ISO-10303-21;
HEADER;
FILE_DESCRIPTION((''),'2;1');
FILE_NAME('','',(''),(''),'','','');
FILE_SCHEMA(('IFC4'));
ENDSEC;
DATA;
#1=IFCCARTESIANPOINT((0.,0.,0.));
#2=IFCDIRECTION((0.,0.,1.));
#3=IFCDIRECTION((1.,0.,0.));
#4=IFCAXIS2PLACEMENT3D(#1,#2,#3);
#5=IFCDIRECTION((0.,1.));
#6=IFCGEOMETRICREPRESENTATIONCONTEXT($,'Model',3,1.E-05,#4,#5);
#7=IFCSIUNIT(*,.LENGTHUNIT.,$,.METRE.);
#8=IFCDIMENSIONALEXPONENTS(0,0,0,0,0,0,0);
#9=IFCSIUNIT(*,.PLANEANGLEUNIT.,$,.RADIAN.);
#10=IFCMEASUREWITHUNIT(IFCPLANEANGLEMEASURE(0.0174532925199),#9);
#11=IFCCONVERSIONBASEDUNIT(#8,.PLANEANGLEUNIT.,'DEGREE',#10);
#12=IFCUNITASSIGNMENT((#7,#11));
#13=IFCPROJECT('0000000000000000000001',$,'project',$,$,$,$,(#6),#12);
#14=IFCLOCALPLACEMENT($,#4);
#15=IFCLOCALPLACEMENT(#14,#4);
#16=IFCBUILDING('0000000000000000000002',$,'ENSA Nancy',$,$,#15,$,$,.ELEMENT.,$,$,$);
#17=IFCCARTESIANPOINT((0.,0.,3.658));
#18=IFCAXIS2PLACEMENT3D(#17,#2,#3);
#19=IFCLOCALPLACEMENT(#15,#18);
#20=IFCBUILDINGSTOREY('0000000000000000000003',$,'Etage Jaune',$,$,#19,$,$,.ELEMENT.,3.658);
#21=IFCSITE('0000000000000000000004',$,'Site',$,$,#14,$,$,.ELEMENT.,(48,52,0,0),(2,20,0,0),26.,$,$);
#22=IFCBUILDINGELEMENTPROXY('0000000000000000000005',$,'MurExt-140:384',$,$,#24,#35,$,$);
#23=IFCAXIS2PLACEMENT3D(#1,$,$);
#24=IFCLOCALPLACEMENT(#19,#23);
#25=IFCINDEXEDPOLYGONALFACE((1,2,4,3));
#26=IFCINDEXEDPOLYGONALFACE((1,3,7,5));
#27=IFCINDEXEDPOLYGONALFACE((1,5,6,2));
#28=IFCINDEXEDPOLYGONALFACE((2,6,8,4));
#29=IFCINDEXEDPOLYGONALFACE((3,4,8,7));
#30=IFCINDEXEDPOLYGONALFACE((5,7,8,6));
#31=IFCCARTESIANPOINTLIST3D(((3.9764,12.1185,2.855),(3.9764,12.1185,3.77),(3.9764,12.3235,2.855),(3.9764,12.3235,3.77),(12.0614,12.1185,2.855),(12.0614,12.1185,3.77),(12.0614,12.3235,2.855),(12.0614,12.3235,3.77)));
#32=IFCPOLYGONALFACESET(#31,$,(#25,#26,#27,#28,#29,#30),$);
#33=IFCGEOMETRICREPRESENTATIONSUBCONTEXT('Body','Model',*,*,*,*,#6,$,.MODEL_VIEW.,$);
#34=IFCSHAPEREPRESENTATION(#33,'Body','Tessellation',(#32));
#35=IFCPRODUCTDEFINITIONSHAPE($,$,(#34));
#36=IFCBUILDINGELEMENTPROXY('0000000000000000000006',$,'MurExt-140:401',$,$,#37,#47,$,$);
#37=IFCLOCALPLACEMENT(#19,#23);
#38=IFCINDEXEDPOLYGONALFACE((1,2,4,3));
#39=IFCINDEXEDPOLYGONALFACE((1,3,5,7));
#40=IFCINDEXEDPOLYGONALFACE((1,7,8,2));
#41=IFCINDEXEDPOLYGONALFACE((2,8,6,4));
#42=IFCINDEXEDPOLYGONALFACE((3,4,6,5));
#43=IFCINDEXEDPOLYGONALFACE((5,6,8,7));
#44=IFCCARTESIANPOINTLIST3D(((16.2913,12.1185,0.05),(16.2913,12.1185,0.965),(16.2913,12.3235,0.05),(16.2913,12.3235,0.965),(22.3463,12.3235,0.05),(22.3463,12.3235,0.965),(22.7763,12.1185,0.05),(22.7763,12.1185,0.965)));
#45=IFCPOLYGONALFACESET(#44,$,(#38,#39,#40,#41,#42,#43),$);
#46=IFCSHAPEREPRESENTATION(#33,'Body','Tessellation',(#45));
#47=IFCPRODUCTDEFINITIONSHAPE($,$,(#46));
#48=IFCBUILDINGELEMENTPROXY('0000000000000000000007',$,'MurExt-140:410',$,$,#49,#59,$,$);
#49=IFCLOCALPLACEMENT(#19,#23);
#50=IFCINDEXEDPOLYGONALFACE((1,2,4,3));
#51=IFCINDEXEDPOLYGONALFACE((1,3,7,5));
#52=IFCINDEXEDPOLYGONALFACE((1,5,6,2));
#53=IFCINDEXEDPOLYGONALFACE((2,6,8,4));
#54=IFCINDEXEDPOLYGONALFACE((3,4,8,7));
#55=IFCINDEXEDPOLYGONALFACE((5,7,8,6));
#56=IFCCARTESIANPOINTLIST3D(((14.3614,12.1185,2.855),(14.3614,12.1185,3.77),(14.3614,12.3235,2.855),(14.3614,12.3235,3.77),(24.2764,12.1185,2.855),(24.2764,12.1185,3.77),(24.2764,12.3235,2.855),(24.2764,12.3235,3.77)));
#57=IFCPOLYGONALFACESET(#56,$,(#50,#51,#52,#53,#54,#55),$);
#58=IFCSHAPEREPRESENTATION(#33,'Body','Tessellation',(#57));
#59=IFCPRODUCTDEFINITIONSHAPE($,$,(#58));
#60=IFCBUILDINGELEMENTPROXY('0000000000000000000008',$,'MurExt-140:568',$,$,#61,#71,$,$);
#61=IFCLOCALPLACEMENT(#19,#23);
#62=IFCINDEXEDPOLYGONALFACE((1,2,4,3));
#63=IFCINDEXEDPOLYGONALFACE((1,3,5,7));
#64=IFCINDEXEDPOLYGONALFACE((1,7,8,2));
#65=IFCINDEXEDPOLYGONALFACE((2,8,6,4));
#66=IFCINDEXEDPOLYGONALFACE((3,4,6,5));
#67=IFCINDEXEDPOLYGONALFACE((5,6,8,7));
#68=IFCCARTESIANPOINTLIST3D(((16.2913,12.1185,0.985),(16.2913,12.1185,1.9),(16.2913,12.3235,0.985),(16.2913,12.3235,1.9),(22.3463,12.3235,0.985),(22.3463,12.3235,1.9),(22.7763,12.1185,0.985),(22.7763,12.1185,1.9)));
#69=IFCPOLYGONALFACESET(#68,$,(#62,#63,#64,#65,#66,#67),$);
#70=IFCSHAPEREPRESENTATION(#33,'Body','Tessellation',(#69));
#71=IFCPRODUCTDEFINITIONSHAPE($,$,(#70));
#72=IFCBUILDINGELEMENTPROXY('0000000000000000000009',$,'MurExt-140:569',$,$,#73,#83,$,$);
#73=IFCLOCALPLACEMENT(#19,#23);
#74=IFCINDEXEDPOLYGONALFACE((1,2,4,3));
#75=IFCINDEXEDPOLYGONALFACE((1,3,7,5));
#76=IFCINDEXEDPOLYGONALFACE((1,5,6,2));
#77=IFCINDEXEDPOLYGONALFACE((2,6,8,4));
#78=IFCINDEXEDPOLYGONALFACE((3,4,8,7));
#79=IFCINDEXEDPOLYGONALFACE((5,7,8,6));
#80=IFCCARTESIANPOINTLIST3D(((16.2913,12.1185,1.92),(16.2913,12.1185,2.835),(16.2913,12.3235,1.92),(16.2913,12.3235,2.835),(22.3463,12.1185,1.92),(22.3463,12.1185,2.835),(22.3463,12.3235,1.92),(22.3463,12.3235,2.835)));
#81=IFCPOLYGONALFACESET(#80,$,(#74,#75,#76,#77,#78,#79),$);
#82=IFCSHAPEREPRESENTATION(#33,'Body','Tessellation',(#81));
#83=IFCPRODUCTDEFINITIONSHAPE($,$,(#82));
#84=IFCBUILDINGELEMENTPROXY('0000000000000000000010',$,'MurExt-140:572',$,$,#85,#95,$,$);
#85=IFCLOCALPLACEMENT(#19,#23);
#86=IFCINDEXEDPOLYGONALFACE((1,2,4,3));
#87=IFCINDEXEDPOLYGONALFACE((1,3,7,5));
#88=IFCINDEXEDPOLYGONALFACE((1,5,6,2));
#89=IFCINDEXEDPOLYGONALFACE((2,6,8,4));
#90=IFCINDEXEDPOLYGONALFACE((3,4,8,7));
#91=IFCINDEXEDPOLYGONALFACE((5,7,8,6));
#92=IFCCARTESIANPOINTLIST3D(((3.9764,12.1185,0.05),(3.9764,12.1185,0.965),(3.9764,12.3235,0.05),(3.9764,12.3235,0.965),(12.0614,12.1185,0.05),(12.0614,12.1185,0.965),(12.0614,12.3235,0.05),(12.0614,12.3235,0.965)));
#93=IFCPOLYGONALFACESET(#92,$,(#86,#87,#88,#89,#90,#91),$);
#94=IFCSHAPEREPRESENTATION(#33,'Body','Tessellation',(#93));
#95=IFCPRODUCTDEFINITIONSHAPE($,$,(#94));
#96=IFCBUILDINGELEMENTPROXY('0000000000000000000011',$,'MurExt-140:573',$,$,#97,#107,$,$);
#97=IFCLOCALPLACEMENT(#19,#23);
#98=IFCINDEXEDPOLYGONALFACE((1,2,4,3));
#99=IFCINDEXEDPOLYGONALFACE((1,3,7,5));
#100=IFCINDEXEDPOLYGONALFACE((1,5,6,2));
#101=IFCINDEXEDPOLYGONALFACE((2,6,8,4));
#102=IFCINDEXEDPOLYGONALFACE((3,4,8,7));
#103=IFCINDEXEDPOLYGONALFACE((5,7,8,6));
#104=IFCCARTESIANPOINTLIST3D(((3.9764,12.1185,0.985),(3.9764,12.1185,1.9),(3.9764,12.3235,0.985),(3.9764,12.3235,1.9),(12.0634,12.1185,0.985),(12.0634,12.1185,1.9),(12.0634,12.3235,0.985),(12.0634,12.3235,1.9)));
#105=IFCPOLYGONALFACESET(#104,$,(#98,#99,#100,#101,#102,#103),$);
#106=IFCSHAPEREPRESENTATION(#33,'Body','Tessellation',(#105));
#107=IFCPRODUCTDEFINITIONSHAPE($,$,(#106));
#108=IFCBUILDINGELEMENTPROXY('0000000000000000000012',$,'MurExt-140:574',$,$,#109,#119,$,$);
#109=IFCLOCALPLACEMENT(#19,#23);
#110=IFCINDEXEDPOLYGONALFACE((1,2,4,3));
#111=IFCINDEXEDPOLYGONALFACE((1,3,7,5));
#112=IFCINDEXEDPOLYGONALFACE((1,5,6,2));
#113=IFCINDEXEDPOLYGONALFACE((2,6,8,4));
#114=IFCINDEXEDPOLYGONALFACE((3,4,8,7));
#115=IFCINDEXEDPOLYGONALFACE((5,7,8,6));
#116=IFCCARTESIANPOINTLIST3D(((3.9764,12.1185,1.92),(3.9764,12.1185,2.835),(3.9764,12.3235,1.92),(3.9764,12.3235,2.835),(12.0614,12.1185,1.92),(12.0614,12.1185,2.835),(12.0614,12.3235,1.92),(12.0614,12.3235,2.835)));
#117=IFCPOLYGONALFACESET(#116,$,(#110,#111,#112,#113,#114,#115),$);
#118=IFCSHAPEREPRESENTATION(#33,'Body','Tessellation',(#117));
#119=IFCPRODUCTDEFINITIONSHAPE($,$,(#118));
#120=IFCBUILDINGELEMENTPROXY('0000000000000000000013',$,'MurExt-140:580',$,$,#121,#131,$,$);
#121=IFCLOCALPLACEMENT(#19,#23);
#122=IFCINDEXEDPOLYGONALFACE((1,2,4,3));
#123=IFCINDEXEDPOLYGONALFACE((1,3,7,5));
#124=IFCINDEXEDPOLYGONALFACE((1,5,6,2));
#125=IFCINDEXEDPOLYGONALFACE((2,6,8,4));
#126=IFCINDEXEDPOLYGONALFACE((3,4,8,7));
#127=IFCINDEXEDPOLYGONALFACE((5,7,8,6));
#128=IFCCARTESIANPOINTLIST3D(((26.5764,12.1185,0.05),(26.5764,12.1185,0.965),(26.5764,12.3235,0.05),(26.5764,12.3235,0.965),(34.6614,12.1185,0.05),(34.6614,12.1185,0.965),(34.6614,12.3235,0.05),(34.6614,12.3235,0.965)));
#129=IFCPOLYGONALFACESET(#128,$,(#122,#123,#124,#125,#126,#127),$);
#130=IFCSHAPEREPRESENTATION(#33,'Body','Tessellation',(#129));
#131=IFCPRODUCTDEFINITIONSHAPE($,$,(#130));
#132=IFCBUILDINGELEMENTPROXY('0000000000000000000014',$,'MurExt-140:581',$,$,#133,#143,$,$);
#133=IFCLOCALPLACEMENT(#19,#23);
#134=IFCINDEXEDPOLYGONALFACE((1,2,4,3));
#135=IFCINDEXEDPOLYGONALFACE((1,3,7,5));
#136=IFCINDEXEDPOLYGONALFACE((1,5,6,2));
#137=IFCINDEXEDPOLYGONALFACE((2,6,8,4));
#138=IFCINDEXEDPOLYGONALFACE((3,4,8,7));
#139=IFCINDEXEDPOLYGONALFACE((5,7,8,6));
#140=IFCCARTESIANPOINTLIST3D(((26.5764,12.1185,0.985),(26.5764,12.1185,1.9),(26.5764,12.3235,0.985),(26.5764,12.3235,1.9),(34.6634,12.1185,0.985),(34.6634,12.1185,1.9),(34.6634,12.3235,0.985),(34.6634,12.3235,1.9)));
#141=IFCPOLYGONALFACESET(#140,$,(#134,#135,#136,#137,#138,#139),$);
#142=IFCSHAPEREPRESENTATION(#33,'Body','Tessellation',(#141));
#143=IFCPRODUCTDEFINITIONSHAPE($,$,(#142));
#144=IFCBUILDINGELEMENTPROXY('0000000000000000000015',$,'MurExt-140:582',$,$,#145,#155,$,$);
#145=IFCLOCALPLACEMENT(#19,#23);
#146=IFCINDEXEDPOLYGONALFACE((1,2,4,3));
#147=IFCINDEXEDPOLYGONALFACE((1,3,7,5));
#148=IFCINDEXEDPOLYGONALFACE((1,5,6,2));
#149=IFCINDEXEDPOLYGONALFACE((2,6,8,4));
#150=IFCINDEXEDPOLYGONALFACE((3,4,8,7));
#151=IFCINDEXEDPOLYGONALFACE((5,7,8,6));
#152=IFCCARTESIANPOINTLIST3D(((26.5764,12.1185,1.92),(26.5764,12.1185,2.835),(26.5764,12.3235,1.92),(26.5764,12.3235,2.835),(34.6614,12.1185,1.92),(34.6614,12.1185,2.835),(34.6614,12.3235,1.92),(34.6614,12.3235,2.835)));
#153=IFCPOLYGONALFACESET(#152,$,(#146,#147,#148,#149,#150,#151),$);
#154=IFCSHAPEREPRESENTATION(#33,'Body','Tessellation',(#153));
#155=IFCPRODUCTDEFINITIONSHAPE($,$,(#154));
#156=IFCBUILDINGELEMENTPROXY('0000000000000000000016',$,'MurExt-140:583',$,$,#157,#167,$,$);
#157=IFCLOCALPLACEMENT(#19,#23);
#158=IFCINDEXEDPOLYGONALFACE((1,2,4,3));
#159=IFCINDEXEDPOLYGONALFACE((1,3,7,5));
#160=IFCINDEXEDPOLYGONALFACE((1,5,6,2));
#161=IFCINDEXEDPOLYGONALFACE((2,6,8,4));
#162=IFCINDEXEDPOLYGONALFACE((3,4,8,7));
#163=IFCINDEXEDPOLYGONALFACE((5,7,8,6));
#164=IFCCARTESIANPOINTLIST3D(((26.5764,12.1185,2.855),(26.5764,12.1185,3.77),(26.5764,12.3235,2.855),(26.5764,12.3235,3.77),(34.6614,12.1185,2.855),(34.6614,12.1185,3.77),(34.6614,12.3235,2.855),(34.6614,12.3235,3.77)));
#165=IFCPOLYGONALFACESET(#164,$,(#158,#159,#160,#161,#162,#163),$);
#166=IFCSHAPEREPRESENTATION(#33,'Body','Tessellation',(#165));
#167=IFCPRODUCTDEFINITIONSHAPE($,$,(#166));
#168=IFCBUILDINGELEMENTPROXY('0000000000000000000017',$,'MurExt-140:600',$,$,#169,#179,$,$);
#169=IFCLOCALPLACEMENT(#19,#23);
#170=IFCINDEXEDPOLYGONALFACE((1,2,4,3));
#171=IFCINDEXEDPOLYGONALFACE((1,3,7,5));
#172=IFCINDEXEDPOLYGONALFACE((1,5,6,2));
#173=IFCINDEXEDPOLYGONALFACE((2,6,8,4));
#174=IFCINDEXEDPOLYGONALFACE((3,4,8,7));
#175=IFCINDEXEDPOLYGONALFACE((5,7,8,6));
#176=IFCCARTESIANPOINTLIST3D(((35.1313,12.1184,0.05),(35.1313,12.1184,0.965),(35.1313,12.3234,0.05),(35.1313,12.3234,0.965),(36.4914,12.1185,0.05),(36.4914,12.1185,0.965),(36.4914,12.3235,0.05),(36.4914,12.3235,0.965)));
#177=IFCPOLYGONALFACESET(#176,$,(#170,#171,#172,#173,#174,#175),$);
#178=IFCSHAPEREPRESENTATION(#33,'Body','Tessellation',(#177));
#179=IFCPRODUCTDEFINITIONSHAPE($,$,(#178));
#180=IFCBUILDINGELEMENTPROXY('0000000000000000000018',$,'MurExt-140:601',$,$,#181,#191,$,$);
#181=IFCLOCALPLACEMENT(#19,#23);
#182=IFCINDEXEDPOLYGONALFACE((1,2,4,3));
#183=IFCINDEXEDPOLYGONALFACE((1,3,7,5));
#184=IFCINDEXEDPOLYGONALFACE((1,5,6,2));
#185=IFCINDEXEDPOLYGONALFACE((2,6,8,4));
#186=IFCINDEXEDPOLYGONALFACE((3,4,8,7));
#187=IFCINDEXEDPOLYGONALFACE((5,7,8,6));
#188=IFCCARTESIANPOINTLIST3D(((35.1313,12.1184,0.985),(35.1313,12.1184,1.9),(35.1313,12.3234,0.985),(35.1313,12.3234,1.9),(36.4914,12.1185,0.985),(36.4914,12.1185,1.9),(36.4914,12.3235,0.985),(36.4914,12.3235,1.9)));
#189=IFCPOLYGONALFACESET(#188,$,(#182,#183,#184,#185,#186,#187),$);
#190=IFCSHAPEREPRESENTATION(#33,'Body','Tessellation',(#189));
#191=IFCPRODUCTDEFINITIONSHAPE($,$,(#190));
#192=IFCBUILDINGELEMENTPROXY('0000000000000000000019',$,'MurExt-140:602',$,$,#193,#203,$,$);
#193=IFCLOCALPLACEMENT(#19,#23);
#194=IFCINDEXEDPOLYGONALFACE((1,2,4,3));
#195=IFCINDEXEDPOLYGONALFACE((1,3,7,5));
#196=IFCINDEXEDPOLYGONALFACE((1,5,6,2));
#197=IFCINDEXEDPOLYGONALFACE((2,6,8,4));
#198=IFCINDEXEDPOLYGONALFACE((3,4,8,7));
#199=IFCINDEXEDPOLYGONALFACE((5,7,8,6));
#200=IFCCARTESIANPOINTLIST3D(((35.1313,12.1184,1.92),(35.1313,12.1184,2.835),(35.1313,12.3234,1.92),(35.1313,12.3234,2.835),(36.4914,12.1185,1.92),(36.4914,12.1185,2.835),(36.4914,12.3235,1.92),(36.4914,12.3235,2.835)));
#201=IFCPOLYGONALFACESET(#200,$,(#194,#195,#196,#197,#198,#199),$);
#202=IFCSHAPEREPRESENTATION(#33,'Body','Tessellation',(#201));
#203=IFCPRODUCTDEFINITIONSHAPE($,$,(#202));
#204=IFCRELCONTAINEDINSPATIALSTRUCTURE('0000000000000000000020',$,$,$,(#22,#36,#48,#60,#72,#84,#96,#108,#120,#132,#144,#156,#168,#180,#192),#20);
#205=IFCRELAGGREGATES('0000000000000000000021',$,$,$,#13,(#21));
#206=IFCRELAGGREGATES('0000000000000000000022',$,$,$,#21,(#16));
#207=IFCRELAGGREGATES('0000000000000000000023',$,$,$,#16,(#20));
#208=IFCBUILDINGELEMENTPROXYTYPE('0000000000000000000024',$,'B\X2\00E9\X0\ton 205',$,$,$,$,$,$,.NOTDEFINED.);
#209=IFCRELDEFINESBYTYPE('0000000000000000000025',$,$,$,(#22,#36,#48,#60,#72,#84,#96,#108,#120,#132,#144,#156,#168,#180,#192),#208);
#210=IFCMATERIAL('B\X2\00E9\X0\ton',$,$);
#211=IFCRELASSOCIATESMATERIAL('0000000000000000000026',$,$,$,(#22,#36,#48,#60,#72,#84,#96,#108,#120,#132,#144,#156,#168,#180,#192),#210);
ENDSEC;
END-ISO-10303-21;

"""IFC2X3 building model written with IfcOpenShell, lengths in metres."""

from ifc_helpers import new_model, entity, si_unit, converted_unit, direction, frame, origin_with_axes, place, context, subcontext, project, spatial, polyline, outline, extrude, material, type_object, element, save


model = new_model("IFC2X3")

# Units and contexts
model_context = context("Model", 3, precision=1e-05, world=origin_with_axes(), true_north=direction((0.0, 1.0)))
body_context = subcontext(model_context, "Body", "Model", "MODEL_VIEW")
ifc_project = project(units=[si_unit("LENGTHUNIT", "METRE"), converted_unit("PLANEANGLEUNIT", "DEGREE", entity("IfcPlaneAngleMeasure", 0.0174532925199), si_unit("PLANEANGLEUNIT", "RADIAN"), dimensions=[0, 0, 0, 0, 0, 0, 0])], contexts=[model_context])

# Site, building, storey
site_placement = place(None, origin_with_axes())
site = spatial("IfcSite", under=ifc_project, at=site_placement, Name="Site", CompositionType="ELEMENT", RefLatitude=(48, 52, 0, 0), RefLongitude=(2, 20, 0, 0), RefElevation=26.0)
building_placement = place(site_placement, origin_with_axes())
building = spatial("IfcBuilding", under=site, at=building_placement, Name="ENSA Nancy", CompositionType="ELEMENT")
storey_placement = place(building_placement, frame((0.0, 0.0, 3.658), z_axis=(0.0, 0.0, 1.0), x_axis=(1.0, 0.0, 0.0)))
storey = spatial("IfcBuildingStorey", under=building, at=storey_placement, Name="Etage Jaune", CompositionType="ELEMENT", Elevation=3.658)

# Building element proxies
ifc_material = material(Name="Béton")
building_element_proxy_type_1 = type_object("IfcBuildingElementProxyType", Name="Béton 205", PredefinedType="NOTDEFINED")
proxy_1_placement = place(storey_placement, frame((3.9764, 12.3235, 2.855), z_axis=(0.0, 0.0, 1.0), x_axis=(1.0, 0.0, 0.0)))
element("IfcBuildingElementProxy", 1, at=proxy_1_placement, inside=storey, type_object=building_element_proxy_type_1, material=ifc_material, Name="MurExt-140:384", context=body_context, shape_type="SweptSolid", body=[
    extrude(outline(polyline([(0.0, -0.205), (8.085, -0.205), (8.085, 0.0), (0.0, 0.0), (0.0, -0.205)])), origin_with_axes(), (0.0, 0.0, 1.0), 0.915),
])
proxy_2_placement = place(storey_placement, frame((16.2913, 12.3235, 0.05), z_axis=(0.0, 0.0, 1.0), x_axis=(1.0, 0.0, 0.0)))
element("IfcBuildingElementProxy", 2, at=proxy_2_placement, inside=storey, type_object=building_element_proxy_type_1, material=ifc_material, Name="MurExt-140:401", context=body_context, shape_type="SweptSolid", body=[
    extrude(outline(polyline([(0.0, -0.205), (6.485, -0.205), (6.055, 0.0), (0.0, 0.0), (0.0, -0.205)])), origin_with_axes(), (0.0, 0.0, 1.0), 0.915),
])
proxy_3_placement = place(storey_placement, frame((14.3614, 12.3235, 2.855), z_axis=(0.0, 0.0, 1.0), x_axis=(1.0, 0.0, 0.0)))
element("IfcBuildingElementProxy", 3, at=proxy_3_placement, inside=storey, type_object=building_element_proxy_type_1, material=ifc_material, Name="MurExt-140:410", context=body_context, shape_type="SweptSolid", body=[
    extrude(outline(polyline([(0.0, -0.205), (9.915, -0.205), (9.915, 0.0), (0.0, 0.0), (0.0, -0.205)])), origin_with_axes(), (0.0, 0.0, 1.0), 0.915),
])
proxy_4_placement = place(storey_placement, frame((16.2913, 12.3235, 0.985), z_axis=(0.0, 0.0, 1.0), x_axis=(1.0, 0.0, 0.0)))
element("IfcBuildingElementProxy", 4, at=proxy_4_placement, inside=storey, type_object=building_element_proxy_type_1, material=ifc_material, Name="MurExt-140:568", context=body_context, shape_type="SweptSolid", body=[
    extrude(outline(polyline([(0.0, -0.205), (6.485, -0.205), (6.055, 0.0), (0.0, 0.0), (0.0, -0.205)])), origin_with_axes(), (0.0, 0.0, 1.0), 0.915),
])
proxy_5_placement = place(storey_placement, frame((16.2913, 12.3235, 1.92), z_axis=(0.0, 0.0, 1.0), x_axis=(1.0, 0.0, 0.0)))
element("IfcBuildingElementProxy", 5, at=proxy_5_placement, inside=storey, type_object=building_element_proxy_type_1, material=ifc_material, Name="MurExt-140:569", context=body_context, shape_type="SweptSolid", body=[
    extrude(outline(polyline([(0.0, -0.205), (6.055, -0.205), (6.055, 0.0), (0.0, 0.0), (0.0, -0.205)])), origin_with_axes(), (0.0, 0.0, 1.0), 0.915),
])
proxy_6_placement = place(storey_placement, frame((3.9764, 12.3235, 0.05), z_axis=(0.0, 0.0, 1.0), x_axis=(1.0, 0.0, 0.0)))
element("IfcBuildingElementProxy", 6, at=proxy_6_placement, inside=storey, type_object=building_element_proxy_type_1, material=ifc_material, Name="MurExt-140:572", context=body_context, shape_type="SweptSolid", body=[
    extrude(outline(polyline([(0.0, -0.205), (8.085, -0.205), (8.085, 0.0), (0.0, 0.0), (0.0, -0.205)])), origin_with_axes(), (0.0, 0.0, 1.0), 0.915),
])
proxy_7_placement = place(storey_placement, frame((3.9764, 12.3235, 0.985), z_axis=(0.0, 0.0, 1.0), x_axis=(1.0, 0.0, 0.0)))
element("IfcBuildingElementProxy", 7, at=proxy_7_placement, inside=storey, type_object=building_element_proxy_type_1, material=ifc_material, Name="MurExt-140:573", context=body_context, shape_type="SweptSolid", body=[
    extrude(outline(polyline([(0.0, -0.205), (8.087, -0.205), (8.087, 0.0), (0.0, 0.0), (0.0, -0.205)])), origin_with_axes(), (0.0, 0.0, 1.0), 0.915),
])
for number, where, z_axis, x_axis, name in (
    (8, (3.9764, 12.3235, 1.92), (0.0, 0.0, 1.0), (1.0, 0.0, 0.0), "MurExt-140:574"),
    (9, (26.5764, 12.3235, 0.05), (0.0, 0.0, 1.0), (1.0, 0.0, 0.0), "MurExt-140:580"),
):
    element("IfcBuildingElementProxy", number, at=place(storey_placement, frame(where, z_axis=z_axis, x_axis=x_axis)), inside=storey, type_object=building_element_proxy_type_1, material=ifc_material, Name=name, context=body_context, shape_type="SweptSolid", body=[
        extrude(outline(polyline([(0.0, -0.205), (8.085, -0.205), (8.085, 0.0), (0.0, 0.0), (0.0, -0.205)])), origin_with_axes(), (0.0, 0.0, 1.0), 0.915),
    ])
proxy_8_placement = place(storey_placement, frame((26.5764, 12.3235, 0.985), z_axis=(0.0, 0.0, 1.0), x_axis=(1.0, 0.0, 0.0)))
element("IfcBuildingElementProxy", 10, at=proxy_8_placement, inside=storey, type_object=building_element_proxy_type_1, material=ifc_material, Name="MurExt-140:581", context=body_context, shape_type="SweptSolid", body=[
    extrude(outline(polyline([(0.0, -0.205), (8.087, -0.205), (8.087, 0.0), (0.0, 0.0), (0.0, -0.205)])), origin_with_axes(), (0.0, 0.0, 1.0), 0.915),
])
for number, where, z_axis, x_axis, name in (
    (11, (26.5764, 12.3235, 1.92), (0.0, 0.0, 1.0), (1.0, 0.0, 0.0), "MurExt-140:582"),
    (12, (26.5764, 12.3235, 2.855), (0.0, 0.0, 1.0), (1.0, 0.0, 0.0), "MurExt-140:583"),
):
    element("IfcBuildingElementProxy", number, at=place(storey_placement, frame(where, z_axis=z_axis, x_axis=x_axis)), inside=storey, type_object=building_element_proxy_type_1, material=ifc_material, Name=name, context=body_context, shape_type="SweptSolid", body=[
        extrude(outline(polyline([(0.0, -0.205), (8.085, -0.205), (8.085, 0.0), (0.0, 0.0), (0.0, -0.205)])), origin_with_axes(), (0.0, 0.0, 1.0), 0.915),
    ])
for number, where, z_axis, x_axis, name in (
    (13, (35.1313, 12.3234, 0.05), (0.0, 0.0, 1.0), (1.0, 0.000034, 0.0), "MurExt-140:600"),
    (14, (35.1313, 12.3234, 0.985), (0.0, 0.0, 1.0), (1.0, 0.000034, 0.0), "MurExt-140:601"),
    (15, (35.1313, 12.3234, 1.92), (0.0, 0.0, 1.0), (1.0, 0.000034, 0.0), "MurExt-140:602"),
):
    element("IfcBuildingElementProxy", number, at=place(storey_placement, frame(where, z_axis=z_axis, x_axis=x_axis)), inside=storey, type_object=building_element_proxy_type_1, material=ifc_material, Name=name, context=body_context, shape_type="SweptSolid", body=[
        extrude(outline(polyline([(0.0, -0.205), (1.3601, -0.205), (1.3601, 0.0), (0.0, 0.0), (0.0, -0.205)])), origin_with_axes(), (0.0, 0.0, 1.0), 0.915),
    ])

save(model, "model.ifc")
